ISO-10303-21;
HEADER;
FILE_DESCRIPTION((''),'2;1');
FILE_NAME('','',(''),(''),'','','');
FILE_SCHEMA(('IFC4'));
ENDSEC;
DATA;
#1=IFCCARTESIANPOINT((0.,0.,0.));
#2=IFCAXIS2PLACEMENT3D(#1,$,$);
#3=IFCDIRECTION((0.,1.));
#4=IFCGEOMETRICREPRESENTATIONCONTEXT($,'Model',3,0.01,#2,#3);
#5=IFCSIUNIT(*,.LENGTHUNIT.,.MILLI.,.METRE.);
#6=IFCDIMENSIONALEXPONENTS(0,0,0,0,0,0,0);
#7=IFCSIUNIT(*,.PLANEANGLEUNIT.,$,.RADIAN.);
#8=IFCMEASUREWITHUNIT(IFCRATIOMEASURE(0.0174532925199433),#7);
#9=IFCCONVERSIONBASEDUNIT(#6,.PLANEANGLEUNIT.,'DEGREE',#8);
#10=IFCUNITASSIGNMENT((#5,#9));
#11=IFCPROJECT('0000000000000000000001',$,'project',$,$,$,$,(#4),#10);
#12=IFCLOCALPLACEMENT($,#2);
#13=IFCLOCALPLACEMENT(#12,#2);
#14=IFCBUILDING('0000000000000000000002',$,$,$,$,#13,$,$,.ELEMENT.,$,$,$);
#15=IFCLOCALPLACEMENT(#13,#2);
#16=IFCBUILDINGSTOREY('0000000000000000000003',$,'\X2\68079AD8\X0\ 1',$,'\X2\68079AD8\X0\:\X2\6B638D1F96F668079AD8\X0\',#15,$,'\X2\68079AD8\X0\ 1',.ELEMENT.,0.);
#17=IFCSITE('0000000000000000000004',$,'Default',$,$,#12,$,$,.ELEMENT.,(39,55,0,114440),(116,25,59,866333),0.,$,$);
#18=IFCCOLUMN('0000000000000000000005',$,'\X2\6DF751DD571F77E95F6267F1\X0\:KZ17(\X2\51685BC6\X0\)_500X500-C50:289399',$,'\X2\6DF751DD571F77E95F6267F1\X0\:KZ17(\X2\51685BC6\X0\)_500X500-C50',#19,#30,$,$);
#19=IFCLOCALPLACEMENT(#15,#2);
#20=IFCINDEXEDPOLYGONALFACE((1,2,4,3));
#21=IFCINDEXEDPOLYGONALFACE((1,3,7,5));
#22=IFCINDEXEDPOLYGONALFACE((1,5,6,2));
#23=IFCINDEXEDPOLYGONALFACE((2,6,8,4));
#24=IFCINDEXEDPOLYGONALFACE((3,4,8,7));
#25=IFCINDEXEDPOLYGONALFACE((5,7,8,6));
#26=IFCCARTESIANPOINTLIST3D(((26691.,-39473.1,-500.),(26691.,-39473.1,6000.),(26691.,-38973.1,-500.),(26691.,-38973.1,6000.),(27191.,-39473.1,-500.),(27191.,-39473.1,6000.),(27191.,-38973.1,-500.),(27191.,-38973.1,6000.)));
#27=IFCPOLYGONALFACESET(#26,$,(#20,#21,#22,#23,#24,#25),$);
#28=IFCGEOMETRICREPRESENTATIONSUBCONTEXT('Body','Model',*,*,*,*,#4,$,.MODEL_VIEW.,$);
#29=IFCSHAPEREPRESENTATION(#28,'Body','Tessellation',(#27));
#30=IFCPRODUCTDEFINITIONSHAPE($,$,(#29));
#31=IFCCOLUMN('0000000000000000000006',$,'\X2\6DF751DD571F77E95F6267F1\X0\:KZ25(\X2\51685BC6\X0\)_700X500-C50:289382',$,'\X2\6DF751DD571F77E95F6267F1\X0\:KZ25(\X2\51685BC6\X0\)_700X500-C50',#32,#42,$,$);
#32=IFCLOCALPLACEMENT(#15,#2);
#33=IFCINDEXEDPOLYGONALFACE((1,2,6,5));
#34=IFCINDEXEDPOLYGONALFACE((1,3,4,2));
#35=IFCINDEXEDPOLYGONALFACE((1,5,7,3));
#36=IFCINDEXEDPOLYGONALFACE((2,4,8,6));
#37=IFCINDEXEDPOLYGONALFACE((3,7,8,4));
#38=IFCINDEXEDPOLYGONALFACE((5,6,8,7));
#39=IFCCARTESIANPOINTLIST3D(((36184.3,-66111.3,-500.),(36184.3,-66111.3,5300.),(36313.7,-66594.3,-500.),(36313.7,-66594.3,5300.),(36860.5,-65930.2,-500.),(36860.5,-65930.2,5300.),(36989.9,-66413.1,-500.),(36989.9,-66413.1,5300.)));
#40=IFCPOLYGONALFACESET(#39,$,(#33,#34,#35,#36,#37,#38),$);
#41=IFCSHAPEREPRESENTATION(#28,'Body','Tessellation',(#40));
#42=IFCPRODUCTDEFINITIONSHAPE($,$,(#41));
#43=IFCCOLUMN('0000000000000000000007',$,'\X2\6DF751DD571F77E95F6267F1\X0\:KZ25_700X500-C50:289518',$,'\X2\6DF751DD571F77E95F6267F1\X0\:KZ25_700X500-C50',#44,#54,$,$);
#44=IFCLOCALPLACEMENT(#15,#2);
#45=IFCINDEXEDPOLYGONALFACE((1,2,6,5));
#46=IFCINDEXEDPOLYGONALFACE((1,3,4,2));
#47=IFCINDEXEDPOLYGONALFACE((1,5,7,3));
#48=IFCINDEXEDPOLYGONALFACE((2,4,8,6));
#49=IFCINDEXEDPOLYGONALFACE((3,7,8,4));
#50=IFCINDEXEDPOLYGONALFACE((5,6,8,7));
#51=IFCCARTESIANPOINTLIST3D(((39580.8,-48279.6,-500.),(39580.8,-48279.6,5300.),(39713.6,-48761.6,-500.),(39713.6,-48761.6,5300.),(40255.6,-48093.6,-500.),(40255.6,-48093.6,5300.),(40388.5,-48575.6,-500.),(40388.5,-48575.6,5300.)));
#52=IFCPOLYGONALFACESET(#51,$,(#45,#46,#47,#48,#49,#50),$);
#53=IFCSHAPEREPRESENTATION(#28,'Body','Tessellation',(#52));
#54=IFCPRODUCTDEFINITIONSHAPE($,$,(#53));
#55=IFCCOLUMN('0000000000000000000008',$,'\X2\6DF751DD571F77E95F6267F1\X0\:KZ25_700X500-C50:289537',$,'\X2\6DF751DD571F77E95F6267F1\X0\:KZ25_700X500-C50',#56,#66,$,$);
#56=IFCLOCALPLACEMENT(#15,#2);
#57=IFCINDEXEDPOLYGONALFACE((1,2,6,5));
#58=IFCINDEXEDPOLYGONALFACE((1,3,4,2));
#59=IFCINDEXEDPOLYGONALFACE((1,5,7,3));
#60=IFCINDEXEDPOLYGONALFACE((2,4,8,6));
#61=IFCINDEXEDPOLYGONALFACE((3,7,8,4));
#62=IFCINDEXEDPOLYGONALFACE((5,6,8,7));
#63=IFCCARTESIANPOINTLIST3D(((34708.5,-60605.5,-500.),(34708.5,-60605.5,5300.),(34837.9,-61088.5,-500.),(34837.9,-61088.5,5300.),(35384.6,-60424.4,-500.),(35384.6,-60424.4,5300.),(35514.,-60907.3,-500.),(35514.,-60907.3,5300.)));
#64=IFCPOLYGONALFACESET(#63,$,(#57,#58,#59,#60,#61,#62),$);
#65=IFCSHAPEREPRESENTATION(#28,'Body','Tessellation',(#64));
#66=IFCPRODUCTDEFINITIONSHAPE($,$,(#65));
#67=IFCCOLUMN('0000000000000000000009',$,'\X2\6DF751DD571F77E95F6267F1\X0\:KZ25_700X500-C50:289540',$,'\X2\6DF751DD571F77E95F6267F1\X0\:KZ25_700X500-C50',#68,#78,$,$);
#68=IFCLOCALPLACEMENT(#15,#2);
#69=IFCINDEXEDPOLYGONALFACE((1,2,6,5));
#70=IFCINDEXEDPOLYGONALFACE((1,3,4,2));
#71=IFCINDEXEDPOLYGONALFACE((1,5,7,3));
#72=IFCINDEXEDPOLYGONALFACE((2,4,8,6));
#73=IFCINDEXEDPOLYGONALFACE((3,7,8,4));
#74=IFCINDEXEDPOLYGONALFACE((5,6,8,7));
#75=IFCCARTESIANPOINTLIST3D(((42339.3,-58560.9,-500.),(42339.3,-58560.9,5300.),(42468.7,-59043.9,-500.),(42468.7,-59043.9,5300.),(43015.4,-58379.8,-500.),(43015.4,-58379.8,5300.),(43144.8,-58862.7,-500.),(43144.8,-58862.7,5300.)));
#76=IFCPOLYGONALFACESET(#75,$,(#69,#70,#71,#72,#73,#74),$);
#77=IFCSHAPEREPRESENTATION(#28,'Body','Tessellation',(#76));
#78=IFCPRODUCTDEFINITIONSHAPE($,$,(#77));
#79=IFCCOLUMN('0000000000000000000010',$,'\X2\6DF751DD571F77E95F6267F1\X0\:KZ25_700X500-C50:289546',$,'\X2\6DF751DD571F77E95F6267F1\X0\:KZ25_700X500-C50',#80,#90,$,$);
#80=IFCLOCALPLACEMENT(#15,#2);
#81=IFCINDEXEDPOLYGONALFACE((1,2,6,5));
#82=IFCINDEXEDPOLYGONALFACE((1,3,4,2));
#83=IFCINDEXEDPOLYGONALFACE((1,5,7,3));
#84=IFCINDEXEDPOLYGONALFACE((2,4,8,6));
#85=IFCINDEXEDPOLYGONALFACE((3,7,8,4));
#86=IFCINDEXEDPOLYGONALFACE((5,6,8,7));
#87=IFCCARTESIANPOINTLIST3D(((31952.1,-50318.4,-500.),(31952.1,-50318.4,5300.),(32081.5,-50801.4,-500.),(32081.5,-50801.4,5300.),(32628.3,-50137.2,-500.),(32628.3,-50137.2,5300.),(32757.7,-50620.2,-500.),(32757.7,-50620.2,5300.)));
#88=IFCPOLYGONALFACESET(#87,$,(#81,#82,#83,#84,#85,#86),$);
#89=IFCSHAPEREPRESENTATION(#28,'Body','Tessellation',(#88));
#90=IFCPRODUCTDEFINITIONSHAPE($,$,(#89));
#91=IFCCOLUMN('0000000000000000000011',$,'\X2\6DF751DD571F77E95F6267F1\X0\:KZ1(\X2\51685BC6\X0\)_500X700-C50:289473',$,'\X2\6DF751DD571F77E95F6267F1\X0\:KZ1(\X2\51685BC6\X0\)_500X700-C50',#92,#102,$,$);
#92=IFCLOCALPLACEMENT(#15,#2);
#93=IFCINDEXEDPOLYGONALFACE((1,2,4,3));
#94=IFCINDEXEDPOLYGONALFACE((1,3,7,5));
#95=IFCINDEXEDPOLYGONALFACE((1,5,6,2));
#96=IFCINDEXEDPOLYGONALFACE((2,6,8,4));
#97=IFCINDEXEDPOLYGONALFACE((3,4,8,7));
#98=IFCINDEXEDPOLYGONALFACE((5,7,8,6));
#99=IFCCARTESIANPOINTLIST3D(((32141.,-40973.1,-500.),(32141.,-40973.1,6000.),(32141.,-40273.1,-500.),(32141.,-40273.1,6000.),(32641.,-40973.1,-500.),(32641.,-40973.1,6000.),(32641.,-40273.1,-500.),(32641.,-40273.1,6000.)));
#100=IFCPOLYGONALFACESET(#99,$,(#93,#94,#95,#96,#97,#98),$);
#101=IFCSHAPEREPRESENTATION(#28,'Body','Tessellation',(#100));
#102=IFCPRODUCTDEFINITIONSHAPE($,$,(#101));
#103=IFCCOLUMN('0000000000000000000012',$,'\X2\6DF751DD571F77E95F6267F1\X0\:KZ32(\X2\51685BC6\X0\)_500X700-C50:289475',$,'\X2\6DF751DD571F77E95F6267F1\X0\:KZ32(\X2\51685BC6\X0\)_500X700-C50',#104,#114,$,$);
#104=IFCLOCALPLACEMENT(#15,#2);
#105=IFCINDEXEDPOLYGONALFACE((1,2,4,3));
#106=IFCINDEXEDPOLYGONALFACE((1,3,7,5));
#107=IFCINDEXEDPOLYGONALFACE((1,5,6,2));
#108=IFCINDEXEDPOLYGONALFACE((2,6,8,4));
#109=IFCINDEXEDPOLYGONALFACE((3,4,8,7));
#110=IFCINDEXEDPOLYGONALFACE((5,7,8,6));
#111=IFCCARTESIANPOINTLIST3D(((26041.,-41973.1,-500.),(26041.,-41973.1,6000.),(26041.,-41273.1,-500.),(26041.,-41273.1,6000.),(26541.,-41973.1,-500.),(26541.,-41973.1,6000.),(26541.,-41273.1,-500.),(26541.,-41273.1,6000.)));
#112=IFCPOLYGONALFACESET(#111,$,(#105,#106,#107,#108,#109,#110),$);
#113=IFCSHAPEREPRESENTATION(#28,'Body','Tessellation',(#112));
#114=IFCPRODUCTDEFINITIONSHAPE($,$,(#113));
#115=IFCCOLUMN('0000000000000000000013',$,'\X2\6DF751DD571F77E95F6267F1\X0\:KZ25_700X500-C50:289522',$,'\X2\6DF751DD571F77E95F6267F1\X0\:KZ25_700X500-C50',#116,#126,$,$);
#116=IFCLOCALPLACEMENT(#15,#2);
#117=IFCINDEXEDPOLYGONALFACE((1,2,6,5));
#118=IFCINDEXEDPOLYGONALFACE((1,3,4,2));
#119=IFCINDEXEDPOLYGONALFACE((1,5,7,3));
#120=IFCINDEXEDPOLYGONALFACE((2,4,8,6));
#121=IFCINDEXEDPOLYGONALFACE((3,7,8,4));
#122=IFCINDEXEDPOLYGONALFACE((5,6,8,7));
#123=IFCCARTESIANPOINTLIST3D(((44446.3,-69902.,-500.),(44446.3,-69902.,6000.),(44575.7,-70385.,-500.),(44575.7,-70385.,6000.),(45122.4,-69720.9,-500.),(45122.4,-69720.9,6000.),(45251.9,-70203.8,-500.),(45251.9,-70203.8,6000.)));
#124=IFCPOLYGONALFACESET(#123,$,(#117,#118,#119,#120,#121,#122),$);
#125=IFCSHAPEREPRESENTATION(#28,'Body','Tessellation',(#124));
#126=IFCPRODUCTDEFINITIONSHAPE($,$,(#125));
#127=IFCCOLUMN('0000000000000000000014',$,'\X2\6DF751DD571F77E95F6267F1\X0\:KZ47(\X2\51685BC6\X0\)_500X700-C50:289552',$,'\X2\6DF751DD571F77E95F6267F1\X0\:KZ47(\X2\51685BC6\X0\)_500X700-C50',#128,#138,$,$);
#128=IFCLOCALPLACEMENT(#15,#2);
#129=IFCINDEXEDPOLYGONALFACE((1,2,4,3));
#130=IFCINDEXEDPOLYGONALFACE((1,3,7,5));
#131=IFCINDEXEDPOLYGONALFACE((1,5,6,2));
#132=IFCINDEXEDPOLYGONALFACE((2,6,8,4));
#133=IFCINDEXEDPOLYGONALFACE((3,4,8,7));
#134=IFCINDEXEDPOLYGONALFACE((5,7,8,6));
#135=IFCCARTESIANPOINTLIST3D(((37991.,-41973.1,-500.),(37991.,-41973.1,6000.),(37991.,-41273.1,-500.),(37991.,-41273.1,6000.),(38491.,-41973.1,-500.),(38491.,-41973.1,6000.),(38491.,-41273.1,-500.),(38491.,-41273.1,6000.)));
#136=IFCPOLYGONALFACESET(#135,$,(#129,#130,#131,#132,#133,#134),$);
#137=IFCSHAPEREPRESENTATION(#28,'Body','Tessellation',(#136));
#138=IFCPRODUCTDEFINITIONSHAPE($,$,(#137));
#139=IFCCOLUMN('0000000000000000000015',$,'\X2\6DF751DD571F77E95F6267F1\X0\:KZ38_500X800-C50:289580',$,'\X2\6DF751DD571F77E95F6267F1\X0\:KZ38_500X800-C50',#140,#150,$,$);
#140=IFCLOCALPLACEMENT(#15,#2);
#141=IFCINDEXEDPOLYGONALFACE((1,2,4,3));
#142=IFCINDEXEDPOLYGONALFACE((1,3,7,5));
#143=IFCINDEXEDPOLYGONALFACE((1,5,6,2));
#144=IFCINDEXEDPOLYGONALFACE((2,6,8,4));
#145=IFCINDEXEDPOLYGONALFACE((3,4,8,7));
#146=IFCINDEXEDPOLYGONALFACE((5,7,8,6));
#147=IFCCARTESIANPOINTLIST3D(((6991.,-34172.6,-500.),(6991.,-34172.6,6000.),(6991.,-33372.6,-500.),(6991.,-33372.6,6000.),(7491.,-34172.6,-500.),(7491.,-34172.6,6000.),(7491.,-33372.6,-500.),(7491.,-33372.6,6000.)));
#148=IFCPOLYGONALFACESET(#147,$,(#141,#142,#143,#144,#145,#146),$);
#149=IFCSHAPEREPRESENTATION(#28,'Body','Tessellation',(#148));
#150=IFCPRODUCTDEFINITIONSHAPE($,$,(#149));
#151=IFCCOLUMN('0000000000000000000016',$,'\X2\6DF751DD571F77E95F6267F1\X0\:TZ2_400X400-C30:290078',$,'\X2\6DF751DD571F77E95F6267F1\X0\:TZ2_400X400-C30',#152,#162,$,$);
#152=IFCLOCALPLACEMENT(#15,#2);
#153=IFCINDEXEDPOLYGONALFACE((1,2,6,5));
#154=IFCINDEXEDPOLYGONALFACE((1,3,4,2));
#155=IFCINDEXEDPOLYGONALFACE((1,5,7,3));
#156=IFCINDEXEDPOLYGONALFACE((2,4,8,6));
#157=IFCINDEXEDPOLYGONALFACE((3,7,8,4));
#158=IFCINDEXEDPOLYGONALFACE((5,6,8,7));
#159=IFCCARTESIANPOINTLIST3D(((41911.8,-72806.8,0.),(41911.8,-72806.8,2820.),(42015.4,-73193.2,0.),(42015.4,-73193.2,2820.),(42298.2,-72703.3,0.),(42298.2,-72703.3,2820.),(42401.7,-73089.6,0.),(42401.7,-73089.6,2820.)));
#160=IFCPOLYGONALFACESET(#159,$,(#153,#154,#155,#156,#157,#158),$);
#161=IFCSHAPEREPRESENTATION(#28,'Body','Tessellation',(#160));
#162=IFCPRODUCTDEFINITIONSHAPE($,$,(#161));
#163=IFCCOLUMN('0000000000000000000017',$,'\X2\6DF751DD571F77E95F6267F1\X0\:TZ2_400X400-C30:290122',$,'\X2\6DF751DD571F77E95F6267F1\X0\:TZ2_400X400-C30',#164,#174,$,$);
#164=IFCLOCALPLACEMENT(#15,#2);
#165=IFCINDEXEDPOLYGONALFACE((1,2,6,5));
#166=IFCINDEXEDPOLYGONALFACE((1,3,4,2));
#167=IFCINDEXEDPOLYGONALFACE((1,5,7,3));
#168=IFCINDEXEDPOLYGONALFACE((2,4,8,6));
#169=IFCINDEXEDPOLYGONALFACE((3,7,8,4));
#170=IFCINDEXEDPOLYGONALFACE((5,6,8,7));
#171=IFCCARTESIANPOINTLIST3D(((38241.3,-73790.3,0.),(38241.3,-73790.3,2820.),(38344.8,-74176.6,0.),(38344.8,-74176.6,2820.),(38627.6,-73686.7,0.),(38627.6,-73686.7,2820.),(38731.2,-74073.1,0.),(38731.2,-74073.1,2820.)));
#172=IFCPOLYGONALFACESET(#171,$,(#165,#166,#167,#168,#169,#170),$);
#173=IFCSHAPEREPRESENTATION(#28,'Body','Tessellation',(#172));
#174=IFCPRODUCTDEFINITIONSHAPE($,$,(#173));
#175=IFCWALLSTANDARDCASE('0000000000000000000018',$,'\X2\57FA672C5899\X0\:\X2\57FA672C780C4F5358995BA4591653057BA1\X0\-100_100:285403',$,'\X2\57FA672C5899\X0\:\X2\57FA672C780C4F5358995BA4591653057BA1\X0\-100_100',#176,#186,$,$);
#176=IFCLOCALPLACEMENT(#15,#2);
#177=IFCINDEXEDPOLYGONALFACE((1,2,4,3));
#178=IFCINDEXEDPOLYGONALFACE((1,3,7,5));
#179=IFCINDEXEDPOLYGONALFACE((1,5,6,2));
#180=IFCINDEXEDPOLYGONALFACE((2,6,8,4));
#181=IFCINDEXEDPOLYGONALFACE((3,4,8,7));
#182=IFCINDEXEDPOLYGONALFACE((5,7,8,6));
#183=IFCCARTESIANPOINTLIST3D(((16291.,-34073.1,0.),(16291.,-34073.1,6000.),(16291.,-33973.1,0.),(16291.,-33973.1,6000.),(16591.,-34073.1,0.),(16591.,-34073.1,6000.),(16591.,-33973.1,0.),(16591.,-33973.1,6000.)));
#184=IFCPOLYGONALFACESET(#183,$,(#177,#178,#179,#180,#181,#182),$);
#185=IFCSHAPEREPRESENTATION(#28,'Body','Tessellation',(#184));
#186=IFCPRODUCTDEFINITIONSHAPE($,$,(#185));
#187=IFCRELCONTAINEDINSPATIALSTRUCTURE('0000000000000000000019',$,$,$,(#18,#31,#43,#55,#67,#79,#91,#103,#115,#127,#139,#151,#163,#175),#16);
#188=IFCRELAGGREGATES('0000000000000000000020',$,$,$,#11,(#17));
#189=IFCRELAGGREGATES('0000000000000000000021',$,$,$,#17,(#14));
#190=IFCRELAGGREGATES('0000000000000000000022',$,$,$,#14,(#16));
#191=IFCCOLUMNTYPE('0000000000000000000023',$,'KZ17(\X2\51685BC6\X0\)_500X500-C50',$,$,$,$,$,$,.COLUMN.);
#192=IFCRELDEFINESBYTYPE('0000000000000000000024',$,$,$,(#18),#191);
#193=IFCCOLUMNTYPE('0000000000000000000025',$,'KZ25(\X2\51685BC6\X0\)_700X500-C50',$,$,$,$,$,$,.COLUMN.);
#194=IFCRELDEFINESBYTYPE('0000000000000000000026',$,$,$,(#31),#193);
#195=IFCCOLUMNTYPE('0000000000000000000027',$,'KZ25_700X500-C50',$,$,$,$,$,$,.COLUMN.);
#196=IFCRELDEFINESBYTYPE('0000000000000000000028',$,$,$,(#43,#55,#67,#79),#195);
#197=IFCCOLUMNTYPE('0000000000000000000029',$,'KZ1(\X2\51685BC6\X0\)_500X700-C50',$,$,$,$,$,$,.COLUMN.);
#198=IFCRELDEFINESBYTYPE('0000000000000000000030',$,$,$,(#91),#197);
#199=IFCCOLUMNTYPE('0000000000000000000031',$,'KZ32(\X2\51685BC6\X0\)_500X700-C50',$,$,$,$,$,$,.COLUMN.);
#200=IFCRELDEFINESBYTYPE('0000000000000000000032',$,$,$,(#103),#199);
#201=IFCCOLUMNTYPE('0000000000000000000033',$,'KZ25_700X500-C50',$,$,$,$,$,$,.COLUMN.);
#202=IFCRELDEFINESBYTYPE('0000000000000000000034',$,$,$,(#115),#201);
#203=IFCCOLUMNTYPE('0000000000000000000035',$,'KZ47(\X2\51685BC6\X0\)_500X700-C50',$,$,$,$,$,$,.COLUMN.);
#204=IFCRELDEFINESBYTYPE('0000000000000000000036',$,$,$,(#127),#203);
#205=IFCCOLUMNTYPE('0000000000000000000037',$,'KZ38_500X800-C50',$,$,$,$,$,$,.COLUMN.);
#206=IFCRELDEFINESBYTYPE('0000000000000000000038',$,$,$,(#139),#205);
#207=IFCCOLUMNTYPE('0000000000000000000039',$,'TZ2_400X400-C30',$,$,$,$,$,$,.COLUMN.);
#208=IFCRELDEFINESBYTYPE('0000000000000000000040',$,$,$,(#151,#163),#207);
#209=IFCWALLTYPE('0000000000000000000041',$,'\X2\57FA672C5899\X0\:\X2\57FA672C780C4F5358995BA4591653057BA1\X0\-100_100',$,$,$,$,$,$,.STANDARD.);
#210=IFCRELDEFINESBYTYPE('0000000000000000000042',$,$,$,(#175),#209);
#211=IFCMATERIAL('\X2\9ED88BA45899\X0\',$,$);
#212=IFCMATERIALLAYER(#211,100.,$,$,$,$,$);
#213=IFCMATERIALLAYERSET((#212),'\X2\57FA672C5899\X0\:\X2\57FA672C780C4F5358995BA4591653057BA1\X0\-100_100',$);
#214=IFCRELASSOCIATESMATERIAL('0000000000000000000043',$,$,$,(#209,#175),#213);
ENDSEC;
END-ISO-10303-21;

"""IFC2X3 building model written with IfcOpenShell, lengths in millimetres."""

from ifc_helpers import new_model, entity, si_unit, converted_unit, direction, frame, frame_2d, origin, origin_2d_with_axis, place, context, subcontext, project, spatial, rectangle, extrude, source, transform, mapped, material, layer, layer_set, layer_usage, type_object, type_shapes, element, save


model = new_model("IFC2X3")

# Units and contexts
model_context = context("Model", 3, precision=0.01, world=origin(), true_north=direction((0.0, 1.0)))
body_context = subcontext(model_context, "Body", "Model", "MODEL_VIEW")
ifc_project = project(units=[si_unit("LENGTHUNIT", "METRE", prefix="MILLI"), converted_unit("PLANEANGLEUNIT", "DEGREE", entity("IfcRatioMeasure", 0.0174532925199433), si_unit("PLANEANGLEUNIT", "RADIAN"), dimensions=[0, 0, 0, 0, 0, 0, 0])], contexts=[model_context])

# Site, building, storey
site_placement = place(None, origin())
site = spatial("IfcSite", under=ifc_project, at=site_placement, Name="Default", CompositionType="ELEMENT", RefLatitude=(39, 55, 0, 114440), RefLongitude=(116, 25, 59, 866333), RefElevation=0.0)
building_placement = place(site_placement, origin())
building = spatial("IfcBuilding", under=site, at=building_placement, CompositionType="ELEMENT")
storey_placement = place(building_placement, origin())
storey = spatial("IfcBuildingStorey", under=building, at=storey_placement, Name="标高 1", ObjectType="标高:正负零标高", LongName="标高 1", CompositionType="ELEMENT", Elevation=0.0)

# Columns
column_type_1 = type_object("IfcColumnType", Name="KZ17(全密)_500X500-C50", PredefinedType="COLUMN")
shared_shape_1 = source(origin(), body_context, "Body", "SweptSolid", [
    extrude(rectangle(XDim=500.0, YDim=500.0, at=origin_2d_with_axis()), frame((0.0, 0.0, -500.0), z_axis=(0.0, 0.0, 1.0), x_axis=(0.0, -1.0, 0.0)), (0.0, 0.0, 1.0), 6500.0),
])
type_shapes(column_type_1, [shared_shape_1])
column_1_placement = place(building_placement, frame((26941.0, -39223.1, 0.0)))
element("IfcColumn", 1, at=column_1_placement, inside=storey, type_object=column_type_1, Name="混凝土矩形柱:KZ17(全密)_500X500-C50:289399", ObjectType="混凝土矩形柱:KZ17(全密)_500X500-C50", context=body_context, shape_type="MappedRepresentation", body=[
    mapped(shared_shape_1, transform((0.0, 0.0, 0.0), scale=1.0)),
])
column_type_2 = type_object("IfcColumnType", Name="KZ25(全密)_700X500-C50", PredefinedType="COLUMN")
shared_shape_2 = source(origin(), body_context, "Body", "SweptSolid", [
    extrude(rectangle(XDim=500.0, YDim=700.0, at=origin_2d_with_axis()), frame((0.0, 0.0, -500.0), z_axis=(0.0, 0.0, 1.0), x_axis=(0.0, -1.0, 0.0)), (0.0, 0.0, 1.0), 5800.0),
])
type_shapes(column_type_2, [shared_shape_2])
column_2_placement = place(building_placement, frame((36587.1, -66262.2, 0.0), z_axis=(0.0, 0.0, 1.0), x_axis=(0.965926, 0.258819, 0.0)))
element("IfcColumn", 2, at=column_2_placement, inside=storey, type_object=column_type_2, Name="混凝土矩形柱:KZ25(全密)_700X500-C50:289382", ObjectType="混凝土矩形柱:KZ25(全密)_700X500-C50", context=body_context, shape_type="MappedRepresentation", body=[
    mapped(shared_shape_2, transform((0.0, 0.0, 0.0), scale=1.0)),
])
column_type_3 = type_object("IfcColumnType", Name="KZ25_700X500-C50", PredefinedType="COLUMN")
shared_shape_3 = source(origin(), body_context, "Body", "SweptSolid", [
    extrude(rectangle(XDim=500.0, YDim=700.0, at=origin_2d_with_axis()), frame((0.0, 0.0, -500.0), z_axis=(0.0, 0.0, 1.0), x_axis=(0.0, -1.0, 0.0)), (0.0, 0.0, 1.0), 5800.0),
])
type_shapes(column_type_3, [shared_shape_3])
for number, where, z_axis, x_axis, name in (
    (3, (39984.6, -48427.6, 0.0), (0.0, 0.0, 1.0), (0.964054, 0.265705, 0.0), "混凝土矩形柱:KZ25_700X500-C50:289518"),
    (4, (35111.2, -60756.4, 0.0), (0.0, 0.0, 1.0), (0.965926, 0.258819, 0.0), "混凝土矩形柱:KZ25_700X500-C50:289537"),
    (5, (42742.1, -58711.8, 0.0), (0.0, 0.0, 1.0), (0.965926, 0.258819, 0.0), "混凝土矩形柱:KZ25_700X500-C50:289540"),
    (6, (32354.9, -50469.3, 0.0), (0.0, 0.0, 1.0), (0.965926, 0.258819, 0.0), "混凝土矩形柱:KZ25_700X500-C50:289546"),
):
    element("IfcColumn", number, at=place(building_placement, frame(where, z_axis=z_axis, x_axis=x_axis)), inside=storey, type_object=column_type_3, Name=name, ObjectType="混凝土矩形柱:KZ25_700X500-C50", context=body_context, shape_type="MappedRepresentation", body=[
        mapped(shared_shape_3, transform((0.0, 0.0, 0.0), scale=1.0)),
    ])
column_type_4 = type_object("IfcColumnType", Name="KZ1(全密)_500X700-C50", PredefinedType="COLUMN")
shared_shape_4 = source(origin(), body_context, "Body", "SweptSolid", [
    extrude(rectangle(XDim=700.0, YDim=500.0, at=origin_2d_with_axis()), frame((0.0, 0.0, -500.0), z_axis=(0.0, 0.0, 1.0), x_axis=(0.0, -1.0, 0.0)), (0.0, 0.0, 1.0), 6500.0),
])
type_shapes(column_type_4, [shared_shape_4])
column_3_placement = place(building_placement, frame((32391.0, -40623.1, 0.0)))
element("IfcColumn", 7, at=column_3_placement, inside=storey, type_object=column_type_4, Name="混凝土矩形柱:KZ1(全密)_500X700-C50:289473", ObjectType="混凝土矩形柱:KZ1(全密)_500X700-C50", context=body_context, shape_type="MappedRepresentation", body=[
    mapped(shared_shape_4, transform((0.0, 0.0, 0.0), scale=1.0)),
])
column_type_5 = type_object("IfcColumnType", Name="KZ32(全密)_500X700-C50", PredefinedType="COLUMN")
shared_shape_5 = source(origin(), body_context, "Body", "SweptSolid", [
    extrude(rectangle(XDim=700.0, YDim=500.0, at=origin_2d_with_axis()), frame((0.0, 0.0, -500.0), z_axis=(0.0, 0.0, 1.0), x_axis=(0.0, -1.0, 0.0)), (0.0, 0.0, 1.0), 6500.0),
])
type_shapes(column_type_5, [shared_shape_5])
column_4_placement = place(building_placement, frame((26291.0, -41623.1, 0.0)))
element("IfcColumn", 8, at=column_4_placement, inside=storey, type_object=column_type_5, Name="混凝土矩形柱:KZ32(全密)_500X700-C50:289475", ObjectType="混凝土矩形柱:KZ32(全密)_500X700-C50", context=body_context, shape_type="MappedRepresentation", body=[
    mapped(shared_shape_5, transform((0.0, 0.0, 0.0), scale=1.0)),
])
column_type_6 = type_object("IfcColumnType", Name="KZ25_700X500-C50", PredefinedType="COLUMN")
shared_shape_6 = source(origin(), body_context, "Body", "SweptSolid", [
    extrude(rectangle(XDim=500.0, YDim=700.0, at=origin_2d_with_axis()), frame((0.0, 0.0, -500.0), z_axis=(0.0, 0.0, 1.0), x_axis=(0.0, -1.0, 0.0)), (0.0, 0.0, 1.0), 6500.0),
])
type_shapes(column_type_6, [shared_shape_6])
column_5_placement = place(building_placement, frame((44849.1, -70052.9, 0.0), z_axis=(0.0, 0.0, 1.0), x_axis=(0.965926, 0.258819, 0.0)))
element("IfcColumn", 9, at=column_5_placement, inside=storey, type_object=column_type_6, Name="混凝土矩形柱:KZ25_700X500-C50:289522", ObjectType="混凝土矩形柱:KZ25_700X500-C50", context=body_context, shape_type="MappedRepresentation", body=[
    mapped(shared_shape_6, transform((0.0, 0.0, 0.0), scale=1.0)),
])
column_type_7 = type_object("IfcColumnType", Name="KZ47(全密)_500X700-C50", PredefinedType="COLUMN")
shared_shape_7 = source(origin(), body_context, "Body", "SweptSolid", [
    extrude(rectangle(XDim=700.0, YDim=500.0, at=origin_2d_with_axis()), frame((0.0, 0.0, -500.0), z_axis=(0.0, 0.0, 1.0), x_axis=(0.0, -1.0, 0.0)), (0.0, 0.0, 1.0), 6500.0),
])
type_shapes(column_type_7, [shared_shape_7])
column_6_placement = place(building_placement, frame((38241.0, -41623.1, 0.0)))
element("IfcColumn", 10, at=column_6_placement, inside=storey, type_object=column_type_7, Name="混凝土矩形柱:KZ47(全密)_500X700-C50:289552", ObjectType="混凝土矩形柱:KZ47(全密)_500X700-C50", context=body_context, shape_type="MappedRepresentation", body=[
    mapped(shared_shape_7, transform((0.0, 0.0, 0.0), scale=1.0)),
])
column_type_8 = type_object("IfcColumnType", Name="KZ38_500X800-C50", PredefinedType="COLUMN")
shared_shape_8 = source(origin(), body_context, "Body", "SweptSolid", [
    extrude(rectangle(XDim=800.0, YDim=500.0, at=origin_2d_with_axis()), frame((0.0, 0.0, -500.0), z_axis=(0.0, 0.0, 1.0), x_axis=(0.0, -1.0, 0.0)), (0.0, 0.0, 1.0), 6500.0),
])
type_shapes(column_type_8, [shared_shape_8])
column_7_placement = place(building_placement, frame((7241.0, -33772.6, 0.0)))
element("IfcColumn", 11, at=column_7_placement, inside=storey, type_object=column_type_8, Name="混凝土矩形柱:KZ38_500X800-C50:289580", ObjectType="混凝土矩形柱:KZ38_500X800-C50", context=body_context, shape_type="MappedRepresentation", body=[
    mapped(shared_shape_8, transform((0.0, 0.0, 0.0), scale=1.0)),
])
column_type_9 = type_object("IfcColumnType", Name="TZ2_400X400-C30", PredefinedType="COLUMN")
shared_shape_9 = source(origin(), body_context, "Body", "SweptSolid", [
    extrude(rectangle(XDim=400.0, YDim=400.0, at=origin_2d_with_axis()), frame((0.0, 0.0, 0.0), z_axis=(0.0, 0.0, 1.0), x_axis=(0.0, -1.0, 0.0)), (0.0, 0.0, 1.0), 2820.0),
])
type_shapes(column_type_9, [shared_shape_9])
for number, where, z_axis, x_axis, name in (
    (12, (42156.8, -72948.2, 0.0), (0.0, 0.0, 1.0), (0.965926, 0.258819, 0.0), "混凝土矩形柱:TZ2_400X400-C30:290078"),
    (13, (38486.2, -73931.7, 0.0), (0.0, 0.0, 1.0), (0.965926, 0.258819, 0.0), "混凝土矩形柱:TZ2_400X400-C30:290122"),
):
    element("IfcColumn", number, at=place(building_placement, frame(where, z_axis=z_axis, x_axis=x_axis)), inside=storey, type_object=column_type_9, Name=name, ObjectType="混凝土矩形柱:TZ2_400X400-C30", context=body_context, shape_type="MappedRepresentation", body=[
        mapped(shared_shape_9, transform((0.0, 0.0, 0.0), scale=1.0)),
    ])

# Wall
ifc_material = material(Name="默认墙")
ifc_layer_1 = layer(ifc_material, 100.0)
ifc_layer_set_1 = layer_set([ifc_layer_1], Name="基本墙:基本砌体墙室外包管-100_100")
ifc_layer_usage_1 = layer_usage(ifc_layer_set_1, "AXIS2", "NEGATIVE", 50.0)
wall_type_1 = type_object("IfcWallType", Name="基本墙:基本砌体墙室外包管-100_100", PredefinedType="STANDARD", material=ifc_layer_set_1)
wall_1_placement = place(building_placement, frame((16291.0, -34023.1, 0.0)))
element("IfcWallStandardCase", 14, at=wall_1_placement, inside=storey, type_object=wall_type_1, material=ifc_layer_usage_1, Name="基本墙:基本砌体墙室外包管-100_100:285403", ObjectType="基本墙:基本砌体墙室外包管-100_100", context=body_context, shape_type="SweptSolid", body=[
    extrude(rectangle(XDim=300.0, YDim=100.0, at=frame_2d((150.0, 0.0), x_axis=(-1.0, 0.0))), origin(), (0.0, 0.0, 1.0), 6000.0),
])

save(model, "model.ifc")
